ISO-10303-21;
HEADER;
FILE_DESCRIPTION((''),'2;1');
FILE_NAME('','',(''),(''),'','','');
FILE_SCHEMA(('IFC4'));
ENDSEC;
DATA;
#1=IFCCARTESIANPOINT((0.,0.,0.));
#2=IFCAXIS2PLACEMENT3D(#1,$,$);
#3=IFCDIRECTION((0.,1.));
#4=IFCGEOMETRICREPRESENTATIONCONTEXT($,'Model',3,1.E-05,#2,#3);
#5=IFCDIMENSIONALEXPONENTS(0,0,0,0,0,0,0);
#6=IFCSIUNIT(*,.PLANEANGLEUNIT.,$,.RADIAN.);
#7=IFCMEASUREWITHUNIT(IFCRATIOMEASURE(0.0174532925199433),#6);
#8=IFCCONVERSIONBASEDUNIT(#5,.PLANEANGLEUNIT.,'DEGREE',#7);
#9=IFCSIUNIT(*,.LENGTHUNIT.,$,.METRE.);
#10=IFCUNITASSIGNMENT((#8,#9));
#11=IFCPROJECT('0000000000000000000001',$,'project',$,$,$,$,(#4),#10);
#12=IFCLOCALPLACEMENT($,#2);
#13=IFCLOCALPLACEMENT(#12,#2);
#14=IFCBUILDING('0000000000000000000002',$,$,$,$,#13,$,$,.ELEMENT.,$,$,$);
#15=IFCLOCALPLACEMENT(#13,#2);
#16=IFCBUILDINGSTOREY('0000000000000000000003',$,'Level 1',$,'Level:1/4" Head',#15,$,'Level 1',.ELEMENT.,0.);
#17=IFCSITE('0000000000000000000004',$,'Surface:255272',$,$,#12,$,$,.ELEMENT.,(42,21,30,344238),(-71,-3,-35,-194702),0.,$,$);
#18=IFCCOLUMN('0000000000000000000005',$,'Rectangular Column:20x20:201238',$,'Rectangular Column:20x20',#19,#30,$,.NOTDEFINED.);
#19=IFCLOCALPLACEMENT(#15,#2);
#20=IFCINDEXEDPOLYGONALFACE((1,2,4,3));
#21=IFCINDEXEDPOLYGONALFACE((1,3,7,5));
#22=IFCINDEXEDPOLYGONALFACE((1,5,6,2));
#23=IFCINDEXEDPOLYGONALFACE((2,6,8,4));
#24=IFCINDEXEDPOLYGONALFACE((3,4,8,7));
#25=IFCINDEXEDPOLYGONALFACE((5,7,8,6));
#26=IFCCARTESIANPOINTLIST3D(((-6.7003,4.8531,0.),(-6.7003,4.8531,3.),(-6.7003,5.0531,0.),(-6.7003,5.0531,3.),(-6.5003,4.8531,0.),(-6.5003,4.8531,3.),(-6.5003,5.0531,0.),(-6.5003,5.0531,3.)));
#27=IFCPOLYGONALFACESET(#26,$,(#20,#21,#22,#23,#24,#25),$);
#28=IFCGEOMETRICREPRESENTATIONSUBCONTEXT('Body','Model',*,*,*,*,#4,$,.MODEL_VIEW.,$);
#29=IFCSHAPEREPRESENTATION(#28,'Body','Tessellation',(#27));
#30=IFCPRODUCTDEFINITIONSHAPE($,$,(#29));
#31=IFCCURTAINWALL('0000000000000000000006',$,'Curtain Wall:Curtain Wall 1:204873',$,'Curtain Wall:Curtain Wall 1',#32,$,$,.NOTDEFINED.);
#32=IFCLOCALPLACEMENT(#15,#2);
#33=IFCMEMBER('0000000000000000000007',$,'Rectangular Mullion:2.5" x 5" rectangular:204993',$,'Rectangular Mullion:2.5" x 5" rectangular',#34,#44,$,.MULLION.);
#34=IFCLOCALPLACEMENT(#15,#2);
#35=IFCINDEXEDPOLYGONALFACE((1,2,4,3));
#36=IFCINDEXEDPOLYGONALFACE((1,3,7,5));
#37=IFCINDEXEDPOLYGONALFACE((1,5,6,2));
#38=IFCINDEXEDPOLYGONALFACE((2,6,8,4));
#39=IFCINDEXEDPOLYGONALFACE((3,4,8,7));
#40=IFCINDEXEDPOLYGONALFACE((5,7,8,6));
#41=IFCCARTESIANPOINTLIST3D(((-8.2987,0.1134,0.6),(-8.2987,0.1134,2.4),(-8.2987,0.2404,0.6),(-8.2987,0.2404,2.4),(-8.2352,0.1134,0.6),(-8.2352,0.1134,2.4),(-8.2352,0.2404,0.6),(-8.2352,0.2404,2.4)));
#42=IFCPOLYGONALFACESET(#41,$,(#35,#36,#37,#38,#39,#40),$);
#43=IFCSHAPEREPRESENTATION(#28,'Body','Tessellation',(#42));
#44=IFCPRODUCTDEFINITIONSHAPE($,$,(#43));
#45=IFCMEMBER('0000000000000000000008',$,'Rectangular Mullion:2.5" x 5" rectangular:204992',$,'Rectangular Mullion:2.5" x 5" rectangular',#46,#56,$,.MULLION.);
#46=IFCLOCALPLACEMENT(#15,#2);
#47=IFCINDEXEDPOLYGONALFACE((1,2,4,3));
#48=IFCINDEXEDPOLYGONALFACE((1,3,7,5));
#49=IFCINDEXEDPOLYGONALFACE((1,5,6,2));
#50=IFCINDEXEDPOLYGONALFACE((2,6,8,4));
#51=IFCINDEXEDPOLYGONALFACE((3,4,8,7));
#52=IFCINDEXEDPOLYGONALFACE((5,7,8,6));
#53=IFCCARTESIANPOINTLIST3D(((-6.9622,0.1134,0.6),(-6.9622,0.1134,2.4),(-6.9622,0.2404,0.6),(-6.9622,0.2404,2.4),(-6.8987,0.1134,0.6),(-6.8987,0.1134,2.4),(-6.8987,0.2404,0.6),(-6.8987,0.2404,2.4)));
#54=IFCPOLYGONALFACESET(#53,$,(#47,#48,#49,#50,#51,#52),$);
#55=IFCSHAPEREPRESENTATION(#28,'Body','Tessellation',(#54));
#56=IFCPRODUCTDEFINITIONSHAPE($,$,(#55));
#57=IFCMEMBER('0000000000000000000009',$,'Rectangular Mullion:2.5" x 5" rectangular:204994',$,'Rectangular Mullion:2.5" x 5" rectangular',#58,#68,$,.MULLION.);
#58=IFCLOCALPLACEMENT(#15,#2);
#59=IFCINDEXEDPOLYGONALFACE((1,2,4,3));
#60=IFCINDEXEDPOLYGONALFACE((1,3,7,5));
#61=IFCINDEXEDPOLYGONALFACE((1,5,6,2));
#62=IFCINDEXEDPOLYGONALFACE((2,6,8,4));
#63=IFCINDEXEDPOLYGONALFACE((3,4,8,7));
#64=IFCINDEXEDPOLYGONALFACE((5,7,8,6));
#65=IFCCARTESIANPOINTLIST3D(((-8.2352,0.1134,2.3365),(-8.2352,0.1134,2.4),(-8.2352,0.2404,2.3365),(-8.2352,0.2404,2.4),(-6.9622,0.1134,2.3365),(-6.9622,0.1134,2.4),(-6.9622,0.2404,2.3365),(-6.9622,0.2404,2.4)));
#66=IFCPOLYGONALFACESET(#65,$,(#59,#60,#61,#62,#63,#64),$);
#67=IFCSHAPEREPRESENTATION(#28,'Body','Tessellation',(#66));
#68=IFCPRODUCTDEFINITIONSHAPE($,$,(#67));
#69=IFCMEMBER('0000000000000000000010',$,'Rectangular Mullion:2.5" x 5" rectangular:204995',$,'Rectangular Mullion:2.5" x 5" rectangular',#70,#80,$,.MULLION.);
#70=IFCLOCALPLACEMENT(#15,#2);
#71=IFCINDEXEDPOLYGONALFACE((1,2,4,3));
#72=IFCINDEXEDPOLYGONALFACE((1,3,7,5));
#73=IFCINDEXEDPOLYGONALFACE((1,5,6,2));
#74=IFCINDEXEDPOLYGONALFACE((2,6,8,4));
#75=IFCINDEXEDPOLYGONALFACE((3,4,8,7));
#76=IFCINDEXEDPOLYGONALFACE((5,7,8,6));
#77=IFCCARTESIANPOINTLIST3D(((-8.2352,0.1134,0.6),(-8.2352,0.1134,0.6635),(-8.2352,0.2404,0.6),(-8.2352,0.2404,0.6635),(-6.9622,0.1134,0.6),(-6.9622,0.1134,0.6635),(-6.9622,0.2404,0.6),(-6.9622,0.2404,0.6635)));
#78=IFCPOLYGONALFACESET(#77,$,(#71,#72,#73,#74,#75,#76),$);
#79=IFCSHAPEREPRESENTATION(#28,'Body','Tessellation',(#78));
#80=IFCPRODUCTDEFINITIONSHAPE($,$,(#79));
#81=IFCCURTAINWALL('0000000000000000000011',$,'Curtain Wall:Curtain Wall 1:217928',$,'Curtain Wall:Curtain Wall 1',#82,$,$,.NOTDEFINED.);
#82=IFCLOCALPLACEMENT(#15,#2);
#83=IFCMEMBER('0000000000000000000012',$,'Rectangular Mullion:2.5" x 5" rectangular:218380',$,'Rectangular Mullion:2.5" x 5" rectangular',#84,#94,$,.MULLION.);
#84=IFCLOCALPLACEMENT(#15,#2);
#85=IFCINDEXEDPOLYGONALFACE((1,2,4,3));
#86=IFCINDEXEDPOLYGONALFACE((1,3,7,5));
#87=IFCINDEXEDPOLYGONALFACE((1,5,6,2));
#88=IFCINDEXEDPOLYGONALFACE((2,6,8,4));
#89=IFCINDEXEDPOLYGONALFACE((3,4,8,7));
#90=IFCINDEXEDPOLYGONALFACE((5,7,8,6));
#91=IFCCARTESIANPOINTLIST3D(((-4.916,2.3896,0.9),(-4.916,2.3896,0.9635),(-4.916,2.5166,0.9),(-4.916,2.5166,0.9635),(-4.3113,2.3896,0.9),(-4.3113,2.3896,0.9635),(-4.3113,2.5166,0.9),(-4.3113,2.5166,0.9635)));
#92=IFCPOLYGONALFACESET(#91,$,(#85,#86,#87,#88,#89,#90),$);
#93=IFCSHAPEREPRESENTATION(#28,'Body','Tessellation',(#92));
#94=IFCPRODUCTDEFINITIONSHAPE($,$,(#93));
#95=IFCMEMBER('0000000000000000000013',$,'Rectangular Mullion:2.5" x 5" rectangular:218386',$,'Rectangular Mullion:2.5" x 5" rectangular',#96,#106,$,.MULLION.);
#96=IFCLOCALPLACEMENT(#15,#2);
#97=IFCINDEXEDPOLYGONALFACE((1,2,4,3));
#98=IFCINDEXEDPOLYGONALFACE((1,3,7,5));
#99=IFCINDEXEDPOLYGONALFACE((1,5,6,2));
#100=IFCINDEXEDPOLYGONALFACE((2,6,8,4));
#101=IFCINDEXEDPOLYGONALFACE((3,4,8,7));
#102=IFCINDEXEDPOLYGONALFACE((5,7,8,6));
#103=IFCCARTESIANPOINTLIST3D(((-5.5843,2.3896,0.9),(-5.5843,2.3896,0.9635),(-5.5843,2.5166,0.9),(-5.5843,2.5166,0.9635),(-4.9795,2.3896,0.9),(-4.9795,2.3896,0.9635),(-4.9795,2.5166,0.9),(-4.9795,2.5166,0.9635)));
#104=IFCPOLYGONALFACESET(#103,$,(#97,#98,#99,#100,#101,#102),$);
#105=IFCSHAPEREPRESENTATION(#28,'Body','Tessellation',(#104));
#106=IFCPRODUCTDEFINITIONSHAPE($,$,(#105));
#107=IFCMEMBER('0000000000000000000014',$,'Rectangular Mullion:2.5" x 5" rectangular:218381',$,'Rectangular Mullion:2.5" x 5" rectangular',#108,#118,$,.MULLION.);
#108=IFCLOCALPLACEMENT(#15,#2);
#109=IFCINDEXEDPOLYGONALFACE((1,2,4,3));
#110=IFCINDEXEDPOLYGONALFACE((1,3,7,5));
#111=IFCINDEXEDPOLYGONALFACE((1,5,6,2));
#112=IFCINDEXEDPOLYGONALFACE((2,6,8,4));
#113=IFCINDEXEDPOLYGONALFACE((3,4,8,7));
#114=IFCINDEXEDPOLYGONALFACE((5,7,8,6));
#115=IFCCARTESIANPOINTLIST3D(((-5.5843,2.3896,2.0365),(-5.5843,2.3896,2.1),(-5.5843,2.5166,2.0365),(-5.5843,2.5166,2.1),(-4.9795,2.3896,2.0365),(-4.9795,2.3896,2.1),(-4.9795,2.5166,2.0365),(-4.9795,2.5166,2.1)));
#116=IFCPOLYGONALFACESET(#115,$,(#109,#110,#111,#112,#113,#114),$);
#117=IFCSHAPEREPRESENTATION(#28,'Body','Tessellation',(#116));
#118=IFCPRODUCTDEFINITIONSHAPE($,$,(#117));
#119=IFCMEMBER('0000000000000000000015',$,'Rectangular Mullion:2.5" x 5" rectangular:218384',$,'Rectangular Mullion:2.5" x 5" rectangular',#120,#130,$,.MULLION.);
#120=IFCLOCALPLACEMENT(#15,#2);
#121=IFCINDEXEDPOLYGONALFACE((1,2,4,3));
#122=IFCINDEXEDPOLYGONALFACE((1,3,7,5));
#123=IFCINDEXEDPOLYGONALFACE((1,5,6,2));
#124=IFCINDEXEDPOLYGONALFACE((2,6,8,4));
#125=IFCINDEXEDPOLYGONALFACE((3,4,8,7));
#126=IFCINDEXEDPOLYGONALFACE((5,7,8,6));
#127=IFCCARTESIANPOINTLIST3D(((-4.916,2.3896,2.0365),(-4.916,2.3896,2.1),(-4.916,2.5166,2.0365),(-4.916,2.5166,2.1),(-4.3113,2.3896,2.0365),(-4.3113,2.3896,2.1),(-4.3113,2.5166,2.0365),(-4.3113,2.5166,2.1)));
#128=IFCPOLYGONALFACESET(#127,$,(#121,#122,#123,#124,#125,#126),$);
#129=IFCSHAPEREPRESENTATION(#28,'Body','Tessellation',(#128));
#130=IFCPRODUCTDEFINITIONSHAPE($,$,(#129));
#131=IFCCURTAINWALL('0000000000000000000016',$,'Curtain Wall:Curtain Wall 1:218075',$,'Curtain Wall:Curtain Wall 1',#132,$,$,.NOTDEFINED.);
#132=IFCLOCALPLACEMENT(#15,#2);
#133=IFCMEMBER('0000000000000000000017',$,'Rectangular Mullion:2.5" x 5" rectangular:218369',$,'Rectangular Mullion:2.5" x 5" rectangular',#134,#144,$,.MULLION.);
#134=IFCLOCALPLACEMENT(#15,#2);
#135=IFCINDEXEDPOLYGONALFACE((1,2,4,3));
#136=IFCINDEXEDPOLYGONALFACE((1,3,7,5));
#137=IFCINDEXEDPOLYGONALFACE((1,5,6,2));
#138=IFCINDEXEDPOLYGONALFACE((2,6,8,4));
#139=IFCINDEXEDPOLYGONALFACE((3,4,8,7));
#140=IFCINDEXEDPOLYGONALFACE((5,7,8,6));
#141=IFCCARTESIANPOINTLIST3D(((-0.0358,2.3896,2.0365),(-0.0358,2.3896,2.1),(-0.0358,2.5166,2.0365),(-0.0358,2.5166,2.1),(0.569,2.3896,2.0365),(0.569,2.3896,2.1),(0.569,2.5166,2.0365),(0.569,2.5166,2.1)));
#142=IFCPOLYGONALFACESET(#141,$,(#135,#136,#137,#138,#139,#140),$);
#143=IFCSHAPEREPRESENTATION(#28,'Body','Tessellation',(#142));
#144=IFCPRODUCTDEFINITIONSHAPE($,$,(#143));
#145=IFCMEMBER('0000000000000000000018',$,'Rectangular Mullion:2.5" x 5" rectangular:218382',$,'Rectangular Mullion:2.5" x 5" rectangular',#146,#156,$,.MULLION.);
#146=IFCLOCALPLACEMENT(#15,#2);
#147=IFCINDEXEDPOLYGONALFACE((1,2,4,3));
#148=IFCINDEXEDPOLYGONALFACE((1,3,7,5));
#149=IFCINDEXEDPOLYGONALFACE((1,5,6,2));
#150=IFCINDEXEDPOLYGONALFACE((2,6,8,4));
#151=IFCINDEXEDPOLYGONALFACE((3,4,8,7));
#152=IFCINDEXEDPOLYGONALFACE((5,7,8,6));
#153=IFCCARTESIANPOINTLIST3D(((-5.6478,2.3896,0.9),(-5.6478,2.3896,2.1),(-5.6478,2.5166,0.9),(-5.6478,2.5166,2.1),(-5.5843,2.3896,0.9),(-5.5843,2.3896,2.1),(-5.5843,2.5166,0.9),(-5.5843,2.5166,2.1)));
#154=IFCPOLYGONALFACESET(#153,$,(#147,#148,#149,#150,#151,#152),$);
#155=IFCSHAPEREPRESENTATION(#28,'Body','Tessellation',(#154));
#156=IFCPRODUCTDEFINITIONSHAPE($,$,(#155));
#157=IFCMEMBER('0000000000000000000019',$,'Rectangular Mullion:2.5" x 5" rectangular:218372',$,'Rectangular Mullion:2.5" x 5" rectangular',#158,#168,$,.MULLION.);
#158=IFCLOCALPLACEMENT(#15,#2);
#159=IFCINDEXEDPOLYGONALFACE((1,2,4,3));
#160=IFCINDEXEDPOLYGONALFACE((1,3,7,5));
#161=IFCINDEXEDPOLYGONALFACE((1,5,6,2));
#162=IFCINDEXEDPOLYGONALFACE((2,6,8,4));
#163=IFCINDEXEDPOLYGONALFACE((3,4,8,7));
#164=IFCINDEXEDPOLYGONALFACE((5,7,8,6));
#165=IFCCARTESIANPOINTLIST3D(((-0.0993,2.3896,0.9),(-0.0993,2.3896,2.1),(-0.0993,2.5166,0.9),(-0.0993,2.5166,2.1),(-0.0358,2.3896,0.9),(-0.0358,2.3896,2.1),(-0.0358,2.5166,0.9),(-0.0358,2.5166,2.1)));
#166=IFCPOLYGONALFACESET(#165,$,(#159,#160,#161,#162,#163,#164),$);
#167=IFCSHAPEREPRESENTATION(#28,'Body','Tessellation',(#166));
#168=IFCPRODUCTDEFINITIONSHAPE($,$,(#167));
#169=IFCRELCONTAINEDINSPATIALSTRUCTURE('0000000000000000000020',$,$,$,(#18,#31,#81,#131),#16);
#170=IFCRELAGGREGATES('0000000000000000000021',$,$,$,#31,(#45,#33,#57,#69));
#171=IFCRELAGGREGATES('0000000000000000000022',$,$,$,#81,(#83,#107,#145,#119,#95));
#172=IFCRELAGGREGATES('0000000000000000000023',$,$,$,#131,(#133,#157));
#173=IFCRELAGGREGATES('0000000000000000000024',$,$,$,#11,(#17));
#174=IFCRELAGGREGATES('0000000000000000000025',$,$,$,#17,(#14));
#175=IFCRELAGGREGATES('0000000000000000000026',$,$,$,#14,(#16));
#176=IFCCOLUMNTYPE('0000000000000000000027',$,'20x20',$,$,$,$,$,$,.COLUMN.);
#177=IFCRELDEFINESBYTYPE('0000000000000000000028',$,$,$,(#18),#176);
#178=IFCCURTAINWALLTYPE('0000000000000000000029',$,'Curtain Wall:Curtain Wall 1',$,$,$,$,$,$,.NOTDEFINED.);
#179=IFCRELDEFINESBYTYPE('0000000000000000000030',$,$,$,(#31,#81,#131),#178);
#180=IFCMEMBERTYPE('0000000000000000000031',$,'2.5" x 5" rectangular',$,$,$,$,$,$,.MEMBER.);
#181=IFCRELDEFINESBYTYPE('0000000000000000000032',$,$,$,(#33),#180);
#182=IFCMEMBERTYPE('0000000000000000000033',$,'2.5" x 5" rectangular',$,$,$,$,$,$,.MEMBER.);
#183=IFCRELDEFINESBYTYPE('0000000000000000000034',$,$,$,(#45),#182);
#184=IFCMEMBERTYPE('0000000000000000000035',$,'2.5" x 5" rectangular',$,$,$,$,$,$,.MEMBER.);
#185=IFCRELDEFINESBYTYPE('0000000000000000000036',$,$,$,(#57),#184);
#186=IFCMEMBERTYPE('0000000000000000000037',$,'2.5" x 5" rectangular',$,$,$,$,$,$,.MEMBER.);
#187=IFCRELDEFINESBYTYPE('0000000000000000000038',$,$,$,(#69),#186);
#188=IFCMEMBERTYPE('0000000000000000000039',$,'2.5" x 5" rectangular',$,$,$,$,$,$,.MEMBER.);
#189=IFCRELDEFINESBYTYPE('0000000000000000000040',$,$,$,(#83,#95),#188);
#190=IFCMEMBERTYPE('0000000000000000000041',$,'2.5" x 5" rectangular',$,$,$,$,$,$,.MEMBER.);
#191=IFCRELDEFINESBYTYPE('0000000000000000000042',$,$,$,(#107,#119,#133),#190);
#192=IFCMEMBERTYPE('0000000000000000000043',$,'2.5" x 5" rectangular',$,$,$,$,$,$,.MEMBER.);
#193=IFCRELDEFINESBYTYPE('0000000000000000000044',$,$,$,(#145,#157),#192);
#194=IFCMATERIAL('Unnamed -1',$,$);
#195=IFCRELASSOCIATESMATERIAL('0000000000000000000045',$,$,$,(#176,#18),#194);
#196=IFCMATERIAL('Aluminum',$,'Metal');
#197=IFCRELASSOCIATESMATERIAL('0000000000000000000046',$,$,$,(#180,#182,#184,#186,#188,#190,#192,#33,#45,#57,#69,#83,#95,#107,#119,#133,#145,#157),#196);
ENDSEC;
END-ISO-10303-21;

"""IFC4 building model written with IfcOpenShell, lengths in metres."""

from ifc_helpers import new_model, entity, si_unit, converted_unit, direction, frame, origin, origin_2d_with_axis, place, context, subcontext, project, spatial, rectangle, extrude, source, transform, mapped, material, material_profile, profile_set, profile_usage, type_object, type_shapes, element, aggregate, save


model = new_model("IFC4")

# Units and contexts
model_context = context("Model", 3, precision=1e-05, world=origin(), true_north=direction((0.0, 1.0)))
body_context = subcontext(model_context, "Body", "Model", "MODEL_VIEW")
ifc_project = project(units=[converted_unit("PLANEANGLEUNIT", "DEGREE", entity("IfcRatioMeasure", 0.0174532925199433), si_unit("PLANEANGLEUNIT", "RADIAN"), dimensions=[0, 0, 0, 0, 0, 0, 0]), si_unit("LENGTHUNIT", "METRE")], contexts=[model_context])

# Site, building, storey
site_placement = place(None, origin())
site = spatial("IfcSite", under=ifc_project, at=site_placement, Name="Surface:255272", CompositionType="ELEMENT", RefLatitude=(42, 21, 30, 344238), RefLongitude=(-71, -3, -35, -194702), RefElevation=0.0)
building_placement = place(site_placement, origin())
building = spatial("IfcBuilding", under=site, at=building_placement, CompositionType="ELEMENT")
storey_placement = place(building_placement, origin())
storey = spatial("IfcBuildingStorey", under=building, at=storey_placement, Name="Level 1", ObjectType="Level:1/4\" Head", LongName="Level 1", CompositionType="ELEMENT", Elevation=0.0)

# Column
ifc_material_1 = material(Name="Unnamed -1")
ifc_material_profile_1 = material_profile(ifc_material_1, rectangle(XDim=0.2, YDim=0.2, at=origin_2d_with_axis()), Name="20x20")
ifc_profile_set_1 = profile_set([ifc_material_profile_1], Name="20x20")
ifc_profile_usage_1 = profile_usage(ifc_profile_set_1)
column_type = type_object("IfcColumnType", Name="20x20", PredefinedType="COLUMN", material=ifc_profile_set_1)
shared_shape_1 = source(origin(), body_context, "Body", "SweptSolid", [
    extrude(rectangle(XDim=0.2, YDim=0.2, at=origin_2d_with_axis()), frame((0.0, 0.0, 0.0), z_axis=(0.0, 0.0, 1.0), x_axis=(0.0, -1.0, 0.0)), (0.0, 0.0, 1.0), 3.0),
])
type_shapes(column_type, [shared_shape_1])
column_placement = place(storey_placement, frame((-6.6003, 4.9531, 0.0)))
element("IfcColumn", 1, at=column_placement, inside=storey, type_object=column_type, material=ifc_profile_usage_1, Name="Rectangular Column:20x20:201238", ObjectType="Rectangular Column:20x20", PredefinedType="NOTDEFINED", context=body_context, shape_type="MappedRepresentation", body=[
    mapped(shared_shape_1, transform((0.0, 0.0, 0.0), scale=1.0)),
])

# Curtain walls, members
curtain_wall_type = type_object("IfcCurtainWallType", Name="Curtain Wall:Curtain Wall 1", PredefinedType="NOTDEFINED")
curtain_wall_1_placement = place(storey_placement, origin())
curtain_wall_1 = element("IfcCurtainWall", 2, at=curtain_wall_1_placement, inside=storey, type_object=curtain_wall_type, Name="Curtain Wall:Curtain Wall 1:204873", ObjectType="Curtain Wall:Curtain Wall 1", PredefinedType="NOTDEFINED")
ifc_material_2 = material(Name="Aluminum", Category="Metal")
ifc_material_profile_2 = material_profile(ifc_material_2, rectangle(XDim=0.127, YDim=0.0635, at=origin_2d_with_axis()), Name="2.5\" x 5\" rectangular")
ifc_profile_set_2 = profile_set([ifc_material_profile_2], Name="2.5\" x 5\" rectangular")
ifc_profile_usage_2 = profile_usage(ifc_profile_set_2)
member_type_1 = type_object("IfcMemberType", Name="2.5\" x 5\" rectangular", PredefinedType="MEMBER", material=ifc_profile_set_2)
shared_shape_2 = source(origin(), body_context, "Body", "SweptSolid", [
    extrude(rectangle(XDim=0.127, YDim=0.0635, at=origin_2d_with_axis()), frame((-0.0318, 0.0, -1.8), z_axis=(0.0, 0.0, 1.0), x_axis=(0.0, -1.0, 0.0)), (0.0, 0.0, 1.0), 1.8),
])
type_shapes(member_type_1, [shared_shape_2])
member_1_placement = place(storey_placement, frame((-8.2987, 0.1769, 2.4), z_axis=(0.0, 0.0, 1.0), x_axis=(-1.0, 0.000007, 0.0)))
member_1 = element("IfcMember", 3, at=member_1_placement, type_object=member_type_1, material=ifc_profile_usage_2, Name="Rectangular Mullion:2.5\" x 5\" rectangular:204993", ObjectType="Rectangular Mullion:2.5\" x 5\" rectangular", PredefinedType="MULLION", context=body_context, shape_type="MappedRepresentation", body=[
    mapped(shared_shape_2, transform((0.0, 0.0, 0.0), scale=1.0)),
])
ifc_profile_usage_3 = profile_usage(ifc_profile_set_2)
member_type_2 = type_object("IfcMemberType", Name="2.5\" x 5\" rectangular", PredefinedType="MEMBER", material=ifc_profile_set_2)
shared_shape_3 = source(origin(), body_context, "Body", "SweptSolid", [
    extrude(rectangle(XDim=0.127, YDim=0.0635, at=origin_2d_with_axis()), frame((-0.0318, 0.0, -1.8), z_axis=(0.0, 0.0, 1.0), x_axis=(0.0, -1.0, 0.0)), (0.0, 0.0, 1.0), 1.8),
])
type_shapes(member_type_2, [shared_shape_3])
member_2_placement = place(storey_placement, frame((-6.8987, 0.1769, 0.6), z_axis=(0.0, 0.0, -1.0), x_axis=(1.0, -0.000007, 0.0)))
member_2 = element("IfcMember", 4, at=member_2_placement, type_object=member_type_2, material=ifc_profile_usage_3, Name="Rectangular Mullion:2.5\" x 5\" rectangular:204992", ObjectType="Rectangular Mullion:2.5\" x 5\" rectangular", PredefinedType="MULLION", context=body_context, shape_type="MappedRepresentation", body=[
    mapped(shared_shape_3, transform((0.0, 0.0, 0.0), scale=1.0)),
])
ifc_profile_usage_4 = profile_usage(ifc_profile_set_2)
member_type_3 = type_object("IfcMemberType", Name="2.5\" x 5\" rectangular", PredefinedType="MEMBER", material=ifc_profile_set_2)
shared_shape_4 = source(origin(), body_context, "Body", "SweptSolid", [
    extrude(rectangle(XDim=0.127, YDim=0.0635, at=origin_2d_with_axis()), frame((-0.0318, 0.0, -1.273), z_axis=(0.0, 0.0, 1.0), x_axis=(0.0, -1.0, 0.0)), (0.0, 0.0, 1.0), 1.273),
])
type_shapes(member_type_3, [shared_shape_4])
member_3_placement = place(storey_placement, frame((-6.9622, 0.1769, 2.4), z_axis=(1.0, -0.000007, 0.0), x_axis=(0.0, 0.0, 1.0)))
member_3 = element("IfcMember", 5, at=member_3_placement, type_object=member_type_3, material=ifc_profile_usage_4, Name="Rectangular Mullion:2.5\" x 5\" rectangular:204994", ObjectType="Rectangular Mullion:2.5\" x 5\" rectangular", PredefinedType="MULLION", context=body_context, shape_type="MappedRepresentation", body=[
    mapped(shared_shape_4, transform((0.0, 0.0, 0.0), scale=1.0)),
])
ifc_profile_usage_5 = profile_usage(ifc_profile_set_2)
member_type_4 = type_object("IfcMemberType", Name="2.5\" x 5\" rectangular", PredefinedType="MEMBER", material=ifc_profile_set_2)
shared_shape_5 = source(origin(), body_context, "Body", "SweptSolid", [
    extrude(rectangle(XDim=0.127, YDim=0.0635, at=origin_2d_with_axis()), frame((-0.0318, 0.0, -1.273), z_axis=(0.0, 0.0, 1.0), x_axis=(0.0, -1.0, 0.0)), (0.0, 0.0, 1.0), 1.273),
])
type_shapes(member_type_4, [shared_shape_5])
member_4_placement = place(storey_placement, frame((-8.2352, 0.1769, 0.6), z_axis=(-1.0, 0.000007, 0.0), x_axis=(0.0, 0.0, -1.0)))
member_4 = element("IfcMember", 6, at=member_4_placement, type_object=member_type_4, material=ifc_profile_usage_5, Name="Rectangular Mullion:2.5\" x 5\" rectangular:204995", ObjectType="Rectangular Mullion:2.5\" x 5\" rectangular", PredefinedType="MULLION", context=body_context, shape_type="MappedRepresentation", body=[
    mapped(shared_shape_5, transform((0.0, 0.0, 0.0), scale=1.0)),
])
curtain_wall_2_placement = place(storey_placement, origin())
curtain_wall_2 = element("IfcCurtainWall", 7, at=curtain_wall_2_placement, inside=storey, type_object=curtain_wall_type, Name="Curtain Wall:Curtain Wall 1:217928", ObjectType="Curtain Wall:Curtain Wall 1", PredefinedType="NOTDEFINED")
ifc_profile_usage_6 = profile_usage(ifc_profile_set_2)
member_type_5 = type_object("IfcMemberType", Name="2.5\" x 5\" rectangular", PredefinedType="MEMBER", material=ifc_profile_set_2)
shared_shape_6 = source(origin(), body_context, "Body", "SweptSolid", [
    extrude(rectangle(XDim=0.127, YDim=0.0635, at=origin_2d_with_axis()), frame((-0.0318, 0.0, -0.6048), z_axis=(0.0, 0.0, 1.0), x_axis=(0.0, -1.0, 0.0)), (0.0, 0.0, 1.0), 0.6048),
])
type_shapes(member_type_5, [shared_shape_6])
member_5_placement = place(storey_placement, frame((-4.3113, 2.4531, 0.9), z_axis=(1.0, -0.000007, 0.0), x_axis=(0.0, 0.0, -1.0)))
member_5 = element("IfcMember", 8, at=member_5_placement, type_object=member_type_5, material=ifc_profile_usage_6, Name="Rectangular Mullion:2.5\" x 5\" rectangular:218380", ObjectType="Rectangular Mullion:2.5\" x 5\" rectangular", PredefinedType="MULLION", context=body_context, shape_type="MappedRepresentation", body=[
    mapped(shared_shape_6, transform((0.0, 0.0, 0.0), scale=1.0)),
])
ifc_profile_usage_7 = profile_usage(ifc_profile_set_2)
member_6_placement = place(storey_placement, frame((-4.9795, 2.4531, 0.9), z_axis=(1.0, -0.000007, 0.0), x_axis=(0.0, 0.0, -1.0)))
member_6 = element("IfcMember", 9, at=member_6_placement, type_object=member_type_5, material=ifc_profile_usage_7, Name="Rectangular Mullion:2.5\" x 5\" rectangular:218386", ObjectType="Rectangular Mullion:2.5\" x 5\" rectangular", PredefinedType="MULLION", context=body_context, shape_type="MappedRepresentation", body=[
    mapped(shared_shape_6, transform((0.0, 0.0, 0.0), scale=1.0)),
])
ifc_profile_usage_8 = profile_usage(ifc_profile_set_2)
member_type_6 = type_object("IfcMemberType", Name="2.5\" x 5\" rectangular", PredefinedType="MEMBER", material=ifc_profile_set_2)
shared_shape_7 = source(origin(), body_context, "Body", "SweptSolid", [
    extrude(rectangle(XDim=0.127, YDim=0.0635, at=origin_2d_with_axis()), frame((-0.0318, 0.0, -0.6048), z_axis=(0.0, 0.0, 1.0), x_axis=(0.0, -1.0, 0.0)), (0.0, 0.0, 1.0), 0.6048),
])
type_shapes(member_type_6, [shared_shape_7])
member_7_placement = place(storey_placement, frame((-5.5843, 2.4531, 2.1), z_axis=(-1.0, 0.000007, 0.0), x_axis=(0.0, 0.0, 1.0)))
member_7 = element("IfcMember", 10, at=member_7_placement, type_object=member_type_6, material=ifc_profile_usage_8, Name="Rectangular Mullion:2.5\" x 5\" rectangular:218381", ObjectType="Rectangular Mullion:2.5\" x 5\" rectangular", PredefinedType="MULLION", context=body_context, shape_type="MappedRepresentation", body=[
    mapped(shared_shape_7, transform((0.0, 0.0, 0.0), scale=1.0)),
])
ifc_profile_usage_9 = profile_usage(ifc_profile_set_2)
member_8_placement = place(storey_placement, frame((-4.916, 2.4531, 2.1), z_axis=(-1.0, 0.000007, 0.0), x_axis=(0.0, 0.0, 1.0)))
member_8 = element("IfcMember", 11, at=member_8_placement, type_object=member_type_6, material=ifc_profile_usage_9, Name="Rectangular Mullion:2.5\" x 5\" rectangular:218384", ObjectType="Rectangular Mullion:2.5\" x 5\" rectangular", PredefinedType="MULLION", context=body_context, shape_type="MappedRepresentation", body=[
    mapped(shared_shape_7, transform((0.0, 0.0, 0.0), scale=1.0)),
])

# Curtain wall, member
curtain_wall_3_placement = place(storey_placement, origin())
curtain_wall_3 = element("IfcCurtainWall", 12, at=curtain_wall_3_placement, inside=storey, type_object=curtain_wall_type, Name="Curtain Wall:Curtain Wall 1:218075", ObjectType="Curtain Wall:Curtain Wall 1", PredefinedType="NOTDEFINED")
ifc_profile_usage_10 = profile_usage(ifc_profile_set_2)
member_9_placement = place(storey_placement, frame((-0.0358, 2.4531, 2.1), z_axis=(-1.0, 0.000007, 0.0), x_axis=(0.0, 0.0, 1.0)))
member_9 = element("IfcMember", 13, at=member_9_placement, type_object=member_type_6, material=ifc_profile_usage_10, Name="Rectangular Mullion:2.5\" x 5\" rectangular:218369", ObjectType="Rectangular Mullion:2.5\" x 5\" rectangular", PredefinedType="MULLION", context=body_context, shape_type="MappedRepresentation", body=[
    mapped(shared_shape_7, transform((0.0, 0.0, 0.0), scale=1.0)),
])

# Members
ifc_profile_usage_11 = profile_usage(ifc_profile_set_2)
member_type_7 = type_object("IfcMemberType", Name="2.5\" x 5\" rectangular", PredefinedType="MEMBER", material=ifc_profile_set_2)
shared_shape_8 = source(origin(), body_context, "Body", "SweptSolid", [
    extrude(rectangle(XDim=0.127, YDim=0.0635, at=origin_2d_with_axis()), frame((-0.0318, 0.0, -1.2), z_axis=(0.0, 0.0, 1.0), x_axis=(0.0, -1.0, 0.0)), (0.0, 0.0, 1.0), 1.2),
])
type_shapes(member_type_7, [shared_shape_8])
member_10_placement = place(storey_placement, frame((-5.6478, 2.4531, 0.9), z_axis=(0.0, 0.0, -1.0), x_axis=(-1.0, 0.000007, 0.0)))
member_10 = element("IfcMember", 14, at=member_10_placement, type_object=member_type_7, material=ifc_profile_usage_11, Name="Rectangular Mullion:2.5\" x 5\" rectangular:218382", ObjectType="Rectangular Mullion:2.5\" x 5\" rectangular", PredefinedType="MULLION", context=body_context, shape_type="MappedRepresentation", body=[
    mapped(shared_shape_8, transform((0.0, 0.0, 0.0), scale=1.0)),
])
ifc_profile_usage_12 = profile_usage(ifc_profile_set_2)
member_11_placement = place(storey_placement, frame((-0.0993, 2.4531, 0.9), z_axis=(0.0, 0.0, -1.0), x_axis=(-1.0, 0.000007, 0.0)))
member_11 = element("IfcMember", 15, at=member_11_placement, type_object=member_type_7, material=ifc_profile_usage_12, Name="Rectangular Mullion:2.5\" x 5\" rectangular:218372", ObjectType="Rectangular Mullion:2.5\" x 5\" rectangular", PredefinedType="MULLION", context=body_context, shape_type="MappedRepresentation", body=[
    mapped(shared_shape_8, transform((0.0, 0.0, 0.0), scale=1.0)),
])

aggregate(curtain_wall_1, [member_2, member_1, member_3, member_4])
aggregate(curtain_wall_2, [member_5, member_7, member_10, member_8, member_6])
aggregate(curtain_wall_3, [member_9, member_11])

save(model, "model.ifc")
